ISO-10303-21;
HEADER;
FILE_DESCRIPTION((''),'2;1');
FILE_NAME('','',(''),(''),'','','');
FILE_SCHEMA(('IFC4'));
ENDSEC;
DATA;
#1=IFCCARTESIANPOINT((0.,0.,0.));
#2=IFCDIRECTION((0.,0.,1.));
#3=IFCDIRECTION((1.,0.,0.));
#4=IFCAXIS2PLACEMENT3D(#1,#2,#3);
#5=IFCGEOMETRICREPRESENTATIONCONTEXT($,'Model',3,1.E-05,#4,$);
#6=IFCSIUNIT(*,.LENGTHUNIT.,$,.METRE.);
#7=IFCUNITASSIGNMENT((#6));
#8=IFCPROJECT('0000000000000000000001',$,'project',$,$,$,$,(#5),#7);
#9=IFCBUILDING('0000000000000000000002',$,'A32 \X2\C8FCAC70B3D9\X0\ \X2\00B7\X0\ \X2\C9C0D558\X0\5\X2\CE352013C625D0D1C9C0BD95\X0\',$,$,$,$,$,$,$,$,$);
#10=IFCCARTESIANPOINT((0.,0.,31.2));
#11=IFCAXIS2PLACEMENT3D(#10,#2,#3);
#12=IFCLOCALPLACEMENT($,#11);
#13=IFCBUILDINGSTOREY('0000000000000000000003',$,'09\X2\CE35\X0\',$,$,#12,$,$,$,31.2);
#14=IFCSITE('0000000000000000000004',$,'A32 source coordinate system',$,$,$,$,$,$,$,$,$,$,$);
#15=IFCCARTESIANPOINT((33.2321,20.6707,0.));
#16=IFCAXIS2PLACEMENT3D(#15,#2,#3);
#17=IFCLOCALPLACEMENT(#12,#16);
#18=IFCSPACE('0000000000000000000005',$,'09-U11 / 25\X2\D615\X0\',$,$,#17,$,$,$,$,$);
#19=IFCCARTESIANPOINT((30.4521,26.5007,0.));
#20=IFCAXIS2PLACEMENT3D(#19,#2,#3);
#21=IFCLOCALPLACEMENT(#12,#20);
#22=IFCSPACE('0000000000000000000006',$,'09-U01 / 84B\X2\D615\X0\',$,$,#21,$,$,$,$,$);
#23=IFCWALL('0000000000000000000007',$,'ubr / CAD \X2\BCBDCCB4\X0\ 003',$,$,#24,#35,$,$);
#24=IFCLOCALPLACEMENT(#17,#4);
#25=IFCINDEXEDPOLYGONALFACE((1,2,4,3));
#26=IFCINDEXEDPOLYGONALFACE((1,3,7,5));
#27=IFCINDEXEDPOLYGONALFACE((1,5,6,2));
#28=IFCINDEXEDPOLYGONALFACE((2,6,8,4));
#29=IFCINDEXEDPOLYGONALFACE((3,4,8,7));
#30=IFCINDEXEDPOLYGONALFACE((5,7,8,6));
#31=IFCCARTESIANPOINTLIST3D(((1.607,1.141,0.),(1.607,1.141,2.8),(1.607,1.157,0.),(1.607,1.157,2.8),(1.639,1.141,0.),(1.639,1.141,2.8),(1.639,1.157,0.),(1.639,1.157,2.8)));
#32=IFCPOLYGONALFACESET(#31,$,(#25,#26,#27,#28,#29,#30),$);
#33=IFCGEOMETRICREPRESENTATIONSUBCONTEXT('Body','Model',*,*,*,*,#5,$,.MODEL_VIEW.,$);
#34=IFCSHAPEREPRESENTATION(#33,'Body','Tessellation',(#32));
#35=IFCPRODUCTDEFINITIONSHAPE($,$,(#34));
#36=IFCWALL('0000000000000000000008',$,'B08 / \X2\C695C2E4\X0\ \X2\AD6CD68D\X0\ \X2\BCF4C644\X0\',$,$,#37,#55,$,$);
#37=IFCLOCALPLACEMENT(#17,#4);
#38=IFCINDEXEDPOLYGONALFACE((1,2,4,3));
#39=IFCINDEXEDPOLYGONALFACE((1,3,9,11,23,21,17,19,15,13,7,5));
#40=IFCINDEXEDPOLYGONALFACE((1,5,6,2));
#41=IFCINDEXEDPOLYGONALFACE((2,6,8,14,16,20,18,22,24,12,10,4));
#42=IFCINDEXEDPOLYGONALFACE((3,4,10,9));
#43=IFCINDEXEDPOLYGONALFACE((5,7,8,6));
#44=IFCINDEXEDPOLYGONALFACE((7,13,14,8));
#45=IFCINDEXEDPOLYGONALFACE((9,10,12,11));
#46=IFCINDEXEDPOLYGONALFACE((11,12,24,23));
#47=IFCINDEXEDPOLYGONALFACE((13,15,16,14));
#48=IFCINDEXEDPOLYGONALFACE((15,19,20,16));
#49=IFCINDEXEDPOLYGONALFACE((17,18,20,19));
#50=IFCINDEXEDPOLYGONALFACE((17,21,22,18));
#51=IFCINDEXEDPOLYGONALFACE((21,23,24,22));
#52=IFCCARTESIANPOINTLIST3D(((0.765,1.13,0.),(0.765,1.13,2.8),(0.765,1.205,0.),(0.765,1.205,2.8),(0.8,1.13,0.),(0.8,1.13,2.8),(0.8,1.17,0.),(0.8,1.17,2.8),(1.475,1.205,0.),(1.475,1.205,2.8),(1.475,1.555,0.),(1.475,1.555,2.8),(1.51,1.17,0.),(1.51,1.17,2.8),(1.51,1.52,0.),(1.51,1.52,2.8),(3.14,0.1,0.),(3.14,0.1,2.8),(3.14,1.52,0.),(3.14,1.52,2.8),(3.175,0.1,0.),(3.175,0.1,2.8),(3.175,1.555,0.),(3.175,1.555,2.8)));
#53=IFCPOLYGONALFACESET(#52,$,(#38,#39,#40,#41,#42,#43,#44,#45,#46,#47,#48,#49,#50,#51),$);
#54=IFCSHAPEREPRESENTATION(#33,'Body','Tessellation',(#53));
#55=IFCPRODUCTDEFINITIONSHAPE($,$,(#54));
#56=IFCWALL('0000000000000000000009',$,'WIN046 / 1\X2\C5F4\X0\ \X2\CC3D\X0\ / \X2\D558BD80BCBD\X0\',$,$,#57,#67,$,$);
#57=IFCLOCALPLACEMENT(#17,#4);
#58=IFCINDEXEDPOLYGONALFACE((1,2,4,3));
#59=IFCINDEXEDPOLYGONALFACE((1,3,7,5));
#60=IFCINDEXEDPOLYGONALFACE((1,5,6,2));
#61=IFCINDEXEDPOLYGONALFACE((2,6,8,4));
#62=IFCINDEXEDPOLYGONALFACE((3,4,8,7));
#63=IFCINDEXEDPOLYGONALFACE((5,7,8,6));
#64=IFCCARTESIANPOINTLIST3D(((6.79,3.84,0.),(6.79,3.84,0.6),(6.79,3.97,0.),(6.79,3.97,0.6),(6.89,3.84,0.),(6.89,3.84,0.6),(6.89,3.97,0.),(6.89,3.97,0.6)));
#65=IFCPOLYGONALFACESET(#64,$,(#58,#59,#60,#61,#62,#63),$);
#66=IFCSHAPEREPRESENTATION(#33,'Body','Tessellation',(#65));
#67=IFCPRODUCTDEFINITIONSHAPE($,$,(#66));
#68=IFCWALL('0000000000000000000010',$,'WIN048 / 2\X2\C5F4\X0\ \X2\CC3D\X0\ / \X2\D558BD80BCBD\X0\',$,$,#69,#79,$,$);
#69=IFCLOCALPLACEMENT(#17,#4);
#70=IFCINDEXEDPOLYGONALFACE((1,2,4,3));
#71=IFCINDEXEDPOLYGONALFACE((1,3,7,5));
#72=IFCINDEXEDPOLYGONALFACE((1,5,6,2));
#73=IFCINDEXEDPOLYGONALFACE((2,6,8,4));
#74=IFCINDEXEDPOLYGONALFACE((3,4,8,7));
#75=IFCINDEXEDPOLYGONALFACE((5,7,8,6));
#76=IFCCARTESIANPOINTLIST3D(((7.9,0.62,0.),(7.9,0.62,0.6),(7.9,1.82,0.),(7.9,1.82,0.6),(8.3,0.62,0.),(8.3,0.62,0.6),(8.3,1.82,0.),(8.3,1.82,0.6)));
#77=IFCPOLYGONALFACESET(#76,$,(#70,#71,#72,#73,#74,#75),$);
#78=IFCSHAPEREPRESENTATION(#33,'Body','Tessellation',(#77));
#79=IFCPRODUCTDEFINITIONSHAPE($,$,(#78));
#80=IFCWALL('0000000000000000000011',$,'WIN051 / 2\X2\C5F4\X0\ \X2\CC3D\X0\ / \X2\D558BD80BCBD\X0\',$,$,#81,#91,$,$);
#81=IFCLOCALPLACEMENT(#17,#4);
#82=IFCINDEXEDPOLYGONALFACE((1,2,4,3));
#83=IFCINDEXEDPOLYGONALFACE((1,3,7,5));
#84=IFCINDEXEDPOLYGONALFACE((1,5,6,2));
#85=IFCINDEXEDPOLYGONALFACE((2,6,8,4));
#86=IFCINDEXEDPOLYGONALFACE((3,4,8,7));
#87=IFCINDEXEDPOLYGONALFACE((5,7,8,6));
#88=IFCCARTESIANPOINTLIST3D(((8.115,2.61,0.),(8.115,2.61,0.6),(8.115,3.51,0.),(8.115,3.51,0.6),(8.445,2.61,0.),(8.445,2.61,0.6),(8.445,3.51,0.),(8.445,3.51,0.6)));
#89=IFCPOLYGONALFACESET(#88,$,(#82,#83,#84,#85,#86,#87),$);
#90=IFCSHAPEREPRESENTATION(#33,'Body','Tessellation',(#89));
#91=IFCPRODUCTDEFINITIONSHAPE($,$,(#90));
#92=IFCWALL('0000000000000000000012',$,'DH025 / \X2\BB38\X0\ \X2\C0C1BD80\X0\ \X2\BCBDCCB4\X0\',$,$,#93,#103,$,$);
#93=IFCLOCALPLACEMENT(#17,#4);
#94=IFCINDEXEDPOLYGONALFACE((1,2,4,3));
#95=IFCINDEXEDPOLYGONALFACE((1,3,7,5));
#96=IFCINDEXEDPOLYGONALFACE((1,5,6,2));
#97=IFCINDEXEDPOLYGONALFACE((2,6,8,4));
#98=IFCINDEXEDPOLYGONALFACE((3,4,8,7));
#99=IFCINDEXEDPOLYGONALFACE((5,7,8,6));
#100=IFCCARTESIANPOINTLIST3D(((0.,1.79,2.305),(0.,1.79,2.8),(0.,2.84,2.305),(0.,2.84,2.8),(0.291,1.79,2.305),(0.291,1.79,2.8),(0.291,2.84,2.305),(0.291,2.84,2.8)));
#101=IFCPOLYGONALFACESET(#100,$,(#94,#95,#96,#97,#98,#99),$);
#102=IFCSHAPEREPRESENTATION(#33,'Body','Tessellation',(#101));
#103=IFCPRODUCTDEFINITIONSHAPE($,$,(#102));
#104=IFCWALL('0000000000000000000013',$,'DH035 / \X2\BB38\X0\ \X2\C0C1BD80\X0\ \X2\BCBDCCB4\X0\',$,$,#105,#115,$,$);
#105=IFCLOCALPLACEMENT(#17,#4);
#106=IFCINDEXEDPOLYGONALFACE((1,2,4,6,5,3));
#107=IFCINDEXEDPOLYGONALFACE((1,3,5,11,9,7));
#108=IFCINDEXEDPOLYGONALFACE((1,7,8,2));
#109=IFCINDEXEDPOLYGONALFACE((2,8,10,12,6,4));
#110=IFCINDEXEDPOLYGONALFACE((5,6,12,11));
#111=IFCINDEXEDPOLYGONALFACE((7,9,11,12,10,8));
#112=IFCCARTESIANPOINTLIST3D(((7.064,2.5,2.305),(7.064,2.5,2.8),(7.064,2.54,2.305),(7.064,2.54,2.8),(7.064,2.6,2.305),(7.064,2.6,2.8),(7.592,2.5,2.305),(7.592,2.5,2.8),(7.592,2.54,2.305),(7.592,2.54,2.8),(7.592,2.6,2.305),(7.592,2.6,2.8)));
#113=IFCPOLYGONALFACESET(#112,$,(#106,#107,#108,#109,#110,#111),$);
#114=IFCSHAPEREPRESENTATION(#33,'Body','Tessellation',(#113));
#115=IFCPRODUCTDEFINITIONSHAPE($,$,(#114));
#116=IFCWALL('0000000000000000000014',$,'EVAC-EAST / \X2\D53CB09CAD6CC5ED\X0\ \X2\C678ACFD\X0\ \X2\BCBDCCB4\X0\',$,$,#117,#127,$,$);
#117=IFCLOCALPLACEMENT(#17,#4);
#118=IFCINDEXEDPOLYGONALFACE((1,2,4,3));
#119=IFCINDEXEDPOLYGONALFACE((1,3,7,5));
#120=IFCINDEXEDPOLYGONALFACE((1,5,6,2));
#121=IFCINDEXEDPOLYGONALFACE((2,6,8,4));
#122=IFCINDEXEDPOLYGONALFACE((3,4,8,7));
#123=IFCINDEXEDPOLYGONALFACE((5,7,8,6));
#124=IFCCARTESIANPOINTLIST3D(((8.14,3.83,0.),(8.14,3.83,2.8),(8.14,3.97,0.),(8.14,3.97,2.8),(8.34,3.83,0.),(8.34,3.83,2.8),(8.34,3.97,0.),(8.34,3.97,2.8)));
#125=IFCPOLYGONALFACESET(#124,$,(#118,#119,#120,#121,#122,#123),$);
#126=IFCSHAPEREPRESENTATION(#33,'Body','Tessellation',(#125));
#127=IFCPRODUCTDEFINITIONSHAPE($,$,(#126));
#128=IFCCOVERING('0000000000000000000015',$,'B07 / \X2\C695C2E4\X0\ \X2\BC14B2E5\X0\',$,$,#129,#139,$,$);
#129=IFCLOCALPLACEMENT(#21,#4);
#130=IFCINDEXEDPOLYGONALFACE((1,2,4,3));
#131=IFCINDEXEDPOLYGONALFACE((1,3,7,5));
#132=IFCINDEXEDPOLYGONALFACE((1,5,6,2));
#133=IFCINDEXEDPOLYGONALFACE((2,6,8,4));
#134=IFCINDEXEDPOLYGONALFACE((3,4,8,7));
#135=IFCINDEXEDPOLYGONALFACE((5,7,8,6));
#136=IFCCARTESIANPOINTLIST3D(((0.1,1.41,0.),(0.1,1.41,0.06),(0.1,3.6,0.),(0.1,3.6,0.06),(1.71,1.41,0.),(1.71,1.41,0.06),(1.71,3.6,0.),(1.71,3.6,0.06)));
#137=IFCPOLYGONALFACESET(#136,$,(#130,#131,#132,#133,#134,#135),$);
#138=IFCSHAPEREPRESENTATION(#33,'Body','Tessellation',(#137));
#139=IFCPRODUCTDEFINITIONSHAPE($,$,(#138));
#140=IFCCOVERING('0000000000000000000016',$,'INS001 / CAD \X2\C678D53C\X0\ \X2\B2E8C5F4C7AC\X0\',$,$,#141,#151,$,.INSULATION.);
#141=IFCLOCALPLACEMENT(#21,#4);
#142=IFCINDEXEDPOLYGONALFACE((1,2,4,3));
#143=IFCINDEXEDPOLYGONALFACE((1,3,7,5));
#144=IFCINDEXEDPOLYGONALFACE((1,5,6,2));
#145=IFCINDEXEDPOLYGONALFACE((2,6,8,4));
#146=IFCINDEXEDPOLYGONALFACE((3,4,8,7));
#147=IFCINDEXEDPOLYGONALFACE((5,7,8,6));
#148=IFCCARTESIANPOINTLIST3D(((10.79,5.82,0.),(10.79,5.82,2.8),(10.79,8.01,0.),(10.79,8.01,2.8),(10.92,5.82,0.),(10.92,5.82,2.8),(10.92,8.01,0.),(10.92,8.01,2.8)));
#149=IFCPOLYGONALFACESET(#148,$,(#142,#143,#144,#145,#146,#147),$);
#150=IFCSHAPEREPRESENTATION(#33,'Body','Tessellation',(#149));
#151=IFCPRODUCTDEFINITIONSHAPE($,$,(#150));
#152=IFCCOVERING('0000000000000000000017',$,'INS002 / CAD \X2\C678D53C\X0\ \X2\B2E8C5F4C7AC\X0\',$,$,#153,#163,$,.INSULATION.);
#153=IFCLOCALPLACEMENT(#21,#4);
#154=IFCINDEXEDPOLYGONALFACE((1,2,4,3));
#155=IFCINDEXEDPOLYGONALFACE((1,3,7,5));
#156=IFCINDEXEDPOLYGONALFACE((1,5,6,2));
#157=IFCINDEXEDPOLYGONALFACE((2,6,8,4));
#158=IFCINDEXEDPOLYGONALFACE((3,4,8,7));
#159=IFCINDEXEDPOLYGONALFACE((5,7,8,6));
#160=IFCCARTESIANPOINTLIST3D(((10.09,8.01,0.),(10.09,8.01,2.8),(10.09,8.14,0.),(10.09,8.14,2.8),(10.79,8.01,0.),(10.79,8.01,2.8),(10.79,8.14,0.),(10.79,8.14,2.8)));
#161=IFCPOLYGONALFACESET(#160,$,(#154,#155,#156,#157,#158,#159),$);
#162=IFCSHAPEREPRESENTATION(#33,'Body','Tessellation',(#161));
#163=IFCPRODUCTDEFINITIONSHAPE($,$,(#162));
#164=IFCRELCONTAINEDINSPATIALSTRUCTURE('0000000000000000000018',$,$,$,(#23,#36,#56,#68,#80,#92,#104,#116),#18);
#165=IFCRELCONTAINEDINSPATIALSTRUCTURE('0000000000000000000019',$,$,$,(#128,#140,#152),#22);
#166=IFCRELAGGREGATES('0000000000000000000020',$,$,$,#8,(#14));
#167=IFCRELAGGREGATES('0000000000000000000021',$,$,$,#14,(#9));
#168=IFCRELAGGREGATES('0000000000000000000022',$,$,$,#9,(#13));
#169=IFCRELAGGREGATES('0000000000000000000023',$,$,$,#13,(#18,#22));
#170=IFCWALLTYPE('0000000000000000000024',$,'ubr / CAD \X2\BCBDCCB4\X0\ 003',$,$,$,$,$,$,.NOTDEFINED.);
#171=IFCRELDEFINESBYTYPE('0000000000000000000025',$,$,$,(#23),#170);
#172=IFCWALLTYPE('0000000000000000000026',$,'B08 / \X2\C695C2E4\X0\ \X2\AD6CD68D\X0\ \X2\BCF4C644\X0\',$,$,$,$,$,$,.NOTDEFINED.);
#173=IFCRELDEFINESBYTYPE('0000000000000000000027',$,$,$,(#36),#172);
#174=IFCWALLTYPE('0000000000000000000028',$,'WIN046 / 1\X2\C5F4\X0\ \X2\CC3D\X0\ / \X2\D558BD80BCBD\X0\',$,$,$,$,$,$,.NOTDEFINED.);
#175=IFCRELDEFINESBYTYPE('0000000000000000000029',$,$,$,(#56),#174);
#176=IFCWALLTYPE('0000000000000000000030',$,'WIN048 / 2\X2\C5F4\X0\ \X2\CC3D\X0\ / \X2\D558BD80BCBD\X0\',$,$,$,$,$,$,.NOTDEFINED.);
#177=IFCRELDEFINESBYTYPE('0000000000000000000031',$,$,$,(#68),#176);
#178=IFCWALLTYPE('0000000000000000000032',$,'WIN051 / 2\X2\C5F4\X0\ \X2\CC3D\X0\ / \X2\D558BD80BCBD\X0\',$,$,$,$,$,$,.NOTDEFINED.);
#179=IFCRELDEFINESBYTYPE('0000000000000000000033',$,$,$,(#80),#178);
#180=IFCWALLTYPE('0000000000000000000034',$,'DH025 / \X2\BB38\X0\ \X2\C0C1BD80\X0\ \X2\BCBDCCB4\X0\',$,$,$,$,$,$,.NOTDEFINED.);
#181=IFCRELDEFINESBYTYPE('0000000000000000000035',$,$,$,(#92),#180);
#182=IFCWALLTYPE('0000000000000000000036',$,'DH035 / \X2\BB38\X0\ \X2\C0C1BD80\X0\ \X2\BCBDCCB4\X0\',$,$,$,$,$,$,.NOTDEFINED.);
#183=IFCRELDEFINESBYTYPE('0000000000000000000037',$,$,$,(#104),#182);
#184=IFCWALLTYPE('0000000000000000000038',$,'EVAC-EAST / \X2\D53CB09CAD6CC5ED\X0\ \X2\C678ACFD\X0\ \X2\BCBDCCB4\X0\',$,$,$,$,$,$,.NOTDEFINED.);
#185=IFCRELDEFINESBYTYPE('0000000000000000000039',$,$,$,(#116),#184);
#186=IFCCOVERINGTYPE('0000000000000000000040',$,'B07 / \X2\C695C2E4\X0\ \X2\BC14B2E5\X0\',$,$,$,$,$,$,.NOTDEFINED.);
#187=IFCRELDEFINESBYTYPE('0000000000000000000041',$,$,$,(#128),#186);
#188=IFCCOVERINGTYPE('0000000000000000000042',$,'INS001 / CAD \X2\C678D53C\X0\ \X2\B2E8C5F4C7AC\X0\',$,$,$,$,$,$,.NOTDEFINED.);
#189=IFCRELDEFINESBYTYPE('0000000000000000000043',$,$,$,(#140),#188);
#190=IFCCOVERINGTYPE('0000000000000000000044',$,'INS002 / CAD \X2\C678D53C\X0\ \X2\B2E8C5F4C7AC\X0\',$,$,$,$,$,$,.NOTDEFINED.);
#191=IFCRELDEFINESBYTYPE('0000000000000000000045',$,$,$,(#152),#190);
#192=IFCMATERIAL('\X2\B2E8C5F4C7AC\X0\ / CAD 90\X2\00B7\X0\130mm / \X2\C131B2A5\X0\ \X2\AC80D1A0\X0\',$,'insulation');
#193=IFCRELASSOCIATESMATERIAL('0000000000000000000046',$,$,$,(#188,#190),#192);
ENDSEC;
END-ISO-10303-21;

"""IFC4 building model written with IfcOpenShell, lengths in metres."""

from ifc_helpers import new_model, si_unit, frame, origin, origin_with_axes, place, context, subcontext, project, spatial, polyline, outline, extrude, source, transform, mapped, material, type_object, type_shapes, element, save


model = new_model("IFC4")

# Units and contexts
model_context = context("Model", 3, precision=1e-05, world=origin_with_axes())
body_context = subcontext(model_context, "Body", "Model", "MODEL_VIEW")
ifc_project = project(units=[si_unit("LENGTHUNIT", "METRE")], contexts=[model_context])

# Site, building, storey, space
site = spatial("IfcSite", under=ifc_project, Name="A32 source coordinate system")
building = spatial("IfcBuilding", under=site, Name="A32 주거동 · 지하5층–옥탑지붕")
storey_placement = place(None, frame((0.0, 0.0, 31.2), z_axis=(0.0, 0.0, 1.0), x_axis=(1.0, 0.0, 0.0)))
storey = spatial("IfcBuildingStorey", under=building, at=storey_placement, Name="09층", Elevation=31.2)
space_1_placement = place(storey_placement, frame((33.2321, 20.6707, 0.0), z_axis=(0.0, 0.0, 1.0), x_axis=(1.0, 0.0, 0.0)))
space_1 = spatial("IfcSpace", under=storey, at=space_1_placement, Name="09-U11 / 25형")

# Walls
wall_type_1 = type_object("IfcWallType", Name="ubr / CAD 벽체 003", PredefinedType="NOTDEFINED")
shared_shape_1 = source(origin(), body_context, "Body", "SweptSolid", [
    extrude(outline(polyline([(1.639, 1.157), (1.639, 1.141), (1.607, 1.141), (1.607, 1.157), (1.639, 1.157)])), origin(), (0.0, 0.0, 1.0), 2.8),
])
type_shapes(wall_type_1, [shared_shape_1])
wall_1_placement = place(space_1_placement, origin_with_axes())
element("IfcWall", 1, at=wall_1_placement, inside=space_1, type_object=wall_type_1, Name="ubr / CAD 벽체 003", context=body_context, shape_type="MappedRepresentation", body=[
    mapped(shared_shape_1, transform((0.0, 0.0, 0.0), scale=1.0)),
])
wall_type_2 = type_object("IfcWallType", Name="B08 / 욕실 구획 보완", PredefinedType="NOTDEFINED")
shared_shape_2 = source(origin(), body_context, "Body", "SweptSolid", [
    extrude(outline(polyline([(0.765, 1.205), (1.475, 1.205), (1.475, 1.555), (3.175, 1.555), (3.175, 0.1), (3.14, 0.1), (3.14, 1.52), (1.51, 1.52), (1.51, 1.17), (0.8, 1.17), (0.8, 1.13), (0.765, 1.13), (0.765, 1.205)])), origin(), (0.0, 0.0, 1.0), 2.8),
])
type_shapes(wall_type_2, [shared_shape_2])
wall_2_placement = place(space_1_placement, origin_with_axes())
element("IfcWall", 2, at=wall_2_placement, inside=space_1, type_object=wall_type_2, Name="B08 / 욕실 구획 보완", context=body_context, shape_type="MappedRepresentation", body=[
    mapped(shared_shape_2, transform((0.0, 0.0, 0.0), scale=1.0)),
])
wall_type_3 = type_object("IfcWallType", Name="WIN046 / 1열 창 / 하부벽", PredefinedType="NOTDEFINED")
shared_shape_3 = source(origin(), body_context, "Body", "SweptSolid", [
    extrude(outline(polyline([(6.89, 3.84), (6.79, 3.84), (6.79, 3.97), (6.89, 3.97), (6.89, 3.84)])), origin(), (0.0, 0.0, 1.0), 0.6),
])
type_shapes(wall_type_3, [shared_shape_3])
wall_3_placement = place(space_1_placement, origin_with_axes())
element("IfcWall", 3, at=wall_3_placement, inside=space_1, type_object=wall_type_3, Name="WIN046 / 1열 창 / 하부벽", context=body_context, shape_type="MappedRepresentation", body=[
    mapped(shared_shape_3, transform((0.0, 0.0, 0.0), scale=1.0)),
])
wall_type_4 = type_object("IfcWallType", Name="WIN048 / 2열 창 / 하부벽", PredefinedType="NOTDEFINED")
shared_shape_4 = source(origin(), body_context, "Body", "SweptSolid", [
    extrude(outline(polyline([(8.3, 0.62), (7.9, 0.62), (7.9, 1.82), (8.3, 1.82), (8.3, 0.62)])), origin(), (0.0, 0.0, 1.0), 0.6),
])
type_shapes(wall_type_4, [shared_shape_4])
wall_4_placement = place(space_1_placement, origin_with_axes())
element("IfcWall", 4, at=wall_4_placement, inside=space_1, type_object=wall_type_4, Name="WIN048 / 2열 창 / 하부벽", context=body_context, shape_type="MappedRepresentation", body=[
    mapped(shared_shape_4, transform((0.0, 0.0, 0.0), scale=1.0)),
])
wall_type_5 = type_object("IfcWallType", Name="WIN051 / 2열 창 / 하부벽", PredefinedType="NOTDEFINED")
shared_shape_5 = source(origin(), body_context, "Body", "SweptSolid", [
    extrude(outline(polyline([(8.445, 2.61), (8.115, 2.61), (8.115, 3.51), (8.445, 3.51), (8.445, 2.61)])), origin(), (0.0, 0.0, 1.0), 0.6),
])
type_shapes(wall_type_5, [shared_shape_5])
wall_5_placement = place(space_1_placement, origin_with_axes())
element("IfcWall", 5, at=wall_5_placement, inside=space_1, type_object=wall_type_5, Name="WIN051 / 2열 창 / 하부벽", context=body_context, shape_type="MappedRepresentation", body=[
    mapped(shared_shape_5, transform((0.0, 0.0, 0.0), scale=1.0)),
])
wall_type_6 = type_object("IfcWallType", Name="DH025 / 문 상부 벽체", PredefinedType="NOTDEFINED")
shared_shape_6 = source(origin(), body_context, "Body", "SweptSolid", [
    extrude(outline(polyline([(0.0, 1.79), (0.0, 2.84), (0.291, 2.84), (0.291, 1.79), (0.0, 1.79)])), frame((0.0, 0.0, 2.305)), (0.0, 0.0, 1.0), 0.495),
])
type_shapes(wall_type_6, [shared_shape_6])
wall_6_placement = place(space_1_placement, origin_with_axes())
element("IfcWall", 6, at=wall_6_placement, inside=space_1, type_object=wall_type_6, Name="DH025 / 문 상부 벽체", context=body_context, shape_type="MappedRepresentation", body=[
    mapped(shared_shape_6, transform((0.0, 0.0, 0.0), scale=1.0)),
])
wall_type_7 = type_object("IfcWallType", Name="DH035 / 문 상부 벽체", PredefinedType="NOTDEFINED")
shared_shape_7 = source(origin(), body_context, "Body", "SweptSolid", [
    extrude(outline(polyline([(7.592, 2.6), (7.592, 2.54), (7.592, 2.5), (7.064, 2.5), (7.064, 2.54), (7.064, 2.6), (7.592, 2.6)])), frame((0.0, 0.0, 2.305)), (0.0, 0.0, 1.0), 0.495),
])
type_shapes(wall_type_7, [shared_shape_7])
wall_7_placement = place(space_1_placement, origin_with_axes())
element("IfcWall", 7, at=wall_7_placement, inside=space_1, type_object=wall_type_7, Name="DH035 / 문 상부 벽체", context=body_context, shape_type="MappedRepresentation", body=[
    mapped(shared_shape_7, transform((0.0, 0.0, 0.0), scale=1.0)),
])
wall_type_8 = type_object("IfcWallType", Name="EVAC-EAST / 피난구역 외곽 벽체", PredefinedType="NOTDEFINED")
shared_shape_8 = source(origin(), body_context, "Body", "SweptSolid", [
    extrude(outline(polyline([(8.34, 3.83), (8.14, 3.83), (8.14, 3.97), (8.34, 3.97), (8.34, 3.83)])), origin(), (0.0, 0.0, 1.0), 2.8),
])
type_shapes(wall_type_8, [shared_shape_8])
wall_8_placement = place(space_1_placement, origin_with_axes())
element("IfcWall", 8, at=wall_8_placement, inside=space_1, type_object=wall_type_8, Name="EVAC-EAST / 피난구역 외곽 벽체", context=body_context, shape_type="MappedRepresentation", body=[
    mapped(shared_shape_8, transform((0.0, 0.0, 0.0), scale=1.0)),
])

# Shared definitions
space_2_placement = place(storey_placement, frame((30.4521, 26.5007, 0.0), z_axis=(0.0, 0.0, 1.0), x_axis=(1.0, 0.0, 0.0)))
space_2 = spatial("IfcSpace", under=storey, at=space_2_placement, Name="09-U01 / 84B형")

# Coverings
covering_type_1 = type_object("IfcCoveringType", Name="B07 / 욕실 바닥", PredefinedType="NOTDEFINED")
shared_shape_9 = source(origin(), body_context, "Body", "SweptSolid", [
    extrude(outline(polyline([(1.71, 1.41), (0.1, 1.41), (0.1, 3.6), (1.71, 3.6), (1.71, 1.41)])), origin(), (0.0, 0.0, 1.0), 0.06),
])
type_shapes(covering_type_1, [shared_shape_9])
covering_1_placement = place(space_2_placement, origin_with_axes())
element("IfcCovering", 9, at=covering_1_placement, inside=space_2, type_object=covering_type_1, Name="B07 / 욕실 바닥", context=body_context, shape_type="MappedRepresentation", body=[
    mapped(shared_shape_9, transform((0.0, 0.0, 0.0), scale=1.0)),
])
ifc_material = material(Name="단열재 / CAD 90·130mm / 성능 검토", Category="insulation")
covering_type_2 = type_object("IfcCoveringType", Name="INS001 / CAD 외피 단열재", PredefinedType="NOTDEFINED", material=ifc_material)
shared_shape_10 = source(origin(), body_context, "Body", "SweptSolid", [
    extrude(outline(polyline([(10.79, 5.82), (10.79, 8.01), (10.92, 8.01), (10.92, 5.82), (10.79, 5.82)])), origin(), (0.0, 0.0, 1.0), 2.8),
])
type_shapes(covering_type_2, [shared_shape_10])
covering_2_placement = place(space_2_placement, origin_with_axes())
element("IfcCovering", 10, at=covering_2_placement, inside=space_2, type_object=covering_type_2, Name="INS001 / CAD 외피 단열재", PredefinedType="INSULATION", context=body_context, shape_type="MappedRepresentation", body=[
    mapped(shared_shape_10, transform((0.0, 0.0, 0.0), scale=1.0)),
])
covering_type_3 = type_object("IfcCoveringType", Name="INS002 / CAD 외피 단열재", PredefinedType="NOTDEFINED", material=ifc_material)
shared_shape_11 = source(origin(), body_context, "Body", "SweptSolid", [
    extrude(outline(polyline([(10.79, 8.01), (10.09, 8.01), (10.09, 8.14), (10.79, 8.14), (10.79, 8.01)])), origin(), (0.0, 0.0, 1.0), 2.8),
])
type_shapes(covering_type_3, [shared_shape_11])
covering_3_placement = place(space_2_placement, origin_with_axes())
element("IfcCovering", 11, at=covering_3_placement, inside=space_2, type_object=covering_type_3, Name="INS002 / CAD 외피 단열재", PredefinedType="INSULATION", context=body_context, shape_type="MappedRepresentation", body=[
    mapped(shared_shape_11, transform((0.0, 0.0, 0.0), scale=1.0)),
])

save(model, "model.ifc")
